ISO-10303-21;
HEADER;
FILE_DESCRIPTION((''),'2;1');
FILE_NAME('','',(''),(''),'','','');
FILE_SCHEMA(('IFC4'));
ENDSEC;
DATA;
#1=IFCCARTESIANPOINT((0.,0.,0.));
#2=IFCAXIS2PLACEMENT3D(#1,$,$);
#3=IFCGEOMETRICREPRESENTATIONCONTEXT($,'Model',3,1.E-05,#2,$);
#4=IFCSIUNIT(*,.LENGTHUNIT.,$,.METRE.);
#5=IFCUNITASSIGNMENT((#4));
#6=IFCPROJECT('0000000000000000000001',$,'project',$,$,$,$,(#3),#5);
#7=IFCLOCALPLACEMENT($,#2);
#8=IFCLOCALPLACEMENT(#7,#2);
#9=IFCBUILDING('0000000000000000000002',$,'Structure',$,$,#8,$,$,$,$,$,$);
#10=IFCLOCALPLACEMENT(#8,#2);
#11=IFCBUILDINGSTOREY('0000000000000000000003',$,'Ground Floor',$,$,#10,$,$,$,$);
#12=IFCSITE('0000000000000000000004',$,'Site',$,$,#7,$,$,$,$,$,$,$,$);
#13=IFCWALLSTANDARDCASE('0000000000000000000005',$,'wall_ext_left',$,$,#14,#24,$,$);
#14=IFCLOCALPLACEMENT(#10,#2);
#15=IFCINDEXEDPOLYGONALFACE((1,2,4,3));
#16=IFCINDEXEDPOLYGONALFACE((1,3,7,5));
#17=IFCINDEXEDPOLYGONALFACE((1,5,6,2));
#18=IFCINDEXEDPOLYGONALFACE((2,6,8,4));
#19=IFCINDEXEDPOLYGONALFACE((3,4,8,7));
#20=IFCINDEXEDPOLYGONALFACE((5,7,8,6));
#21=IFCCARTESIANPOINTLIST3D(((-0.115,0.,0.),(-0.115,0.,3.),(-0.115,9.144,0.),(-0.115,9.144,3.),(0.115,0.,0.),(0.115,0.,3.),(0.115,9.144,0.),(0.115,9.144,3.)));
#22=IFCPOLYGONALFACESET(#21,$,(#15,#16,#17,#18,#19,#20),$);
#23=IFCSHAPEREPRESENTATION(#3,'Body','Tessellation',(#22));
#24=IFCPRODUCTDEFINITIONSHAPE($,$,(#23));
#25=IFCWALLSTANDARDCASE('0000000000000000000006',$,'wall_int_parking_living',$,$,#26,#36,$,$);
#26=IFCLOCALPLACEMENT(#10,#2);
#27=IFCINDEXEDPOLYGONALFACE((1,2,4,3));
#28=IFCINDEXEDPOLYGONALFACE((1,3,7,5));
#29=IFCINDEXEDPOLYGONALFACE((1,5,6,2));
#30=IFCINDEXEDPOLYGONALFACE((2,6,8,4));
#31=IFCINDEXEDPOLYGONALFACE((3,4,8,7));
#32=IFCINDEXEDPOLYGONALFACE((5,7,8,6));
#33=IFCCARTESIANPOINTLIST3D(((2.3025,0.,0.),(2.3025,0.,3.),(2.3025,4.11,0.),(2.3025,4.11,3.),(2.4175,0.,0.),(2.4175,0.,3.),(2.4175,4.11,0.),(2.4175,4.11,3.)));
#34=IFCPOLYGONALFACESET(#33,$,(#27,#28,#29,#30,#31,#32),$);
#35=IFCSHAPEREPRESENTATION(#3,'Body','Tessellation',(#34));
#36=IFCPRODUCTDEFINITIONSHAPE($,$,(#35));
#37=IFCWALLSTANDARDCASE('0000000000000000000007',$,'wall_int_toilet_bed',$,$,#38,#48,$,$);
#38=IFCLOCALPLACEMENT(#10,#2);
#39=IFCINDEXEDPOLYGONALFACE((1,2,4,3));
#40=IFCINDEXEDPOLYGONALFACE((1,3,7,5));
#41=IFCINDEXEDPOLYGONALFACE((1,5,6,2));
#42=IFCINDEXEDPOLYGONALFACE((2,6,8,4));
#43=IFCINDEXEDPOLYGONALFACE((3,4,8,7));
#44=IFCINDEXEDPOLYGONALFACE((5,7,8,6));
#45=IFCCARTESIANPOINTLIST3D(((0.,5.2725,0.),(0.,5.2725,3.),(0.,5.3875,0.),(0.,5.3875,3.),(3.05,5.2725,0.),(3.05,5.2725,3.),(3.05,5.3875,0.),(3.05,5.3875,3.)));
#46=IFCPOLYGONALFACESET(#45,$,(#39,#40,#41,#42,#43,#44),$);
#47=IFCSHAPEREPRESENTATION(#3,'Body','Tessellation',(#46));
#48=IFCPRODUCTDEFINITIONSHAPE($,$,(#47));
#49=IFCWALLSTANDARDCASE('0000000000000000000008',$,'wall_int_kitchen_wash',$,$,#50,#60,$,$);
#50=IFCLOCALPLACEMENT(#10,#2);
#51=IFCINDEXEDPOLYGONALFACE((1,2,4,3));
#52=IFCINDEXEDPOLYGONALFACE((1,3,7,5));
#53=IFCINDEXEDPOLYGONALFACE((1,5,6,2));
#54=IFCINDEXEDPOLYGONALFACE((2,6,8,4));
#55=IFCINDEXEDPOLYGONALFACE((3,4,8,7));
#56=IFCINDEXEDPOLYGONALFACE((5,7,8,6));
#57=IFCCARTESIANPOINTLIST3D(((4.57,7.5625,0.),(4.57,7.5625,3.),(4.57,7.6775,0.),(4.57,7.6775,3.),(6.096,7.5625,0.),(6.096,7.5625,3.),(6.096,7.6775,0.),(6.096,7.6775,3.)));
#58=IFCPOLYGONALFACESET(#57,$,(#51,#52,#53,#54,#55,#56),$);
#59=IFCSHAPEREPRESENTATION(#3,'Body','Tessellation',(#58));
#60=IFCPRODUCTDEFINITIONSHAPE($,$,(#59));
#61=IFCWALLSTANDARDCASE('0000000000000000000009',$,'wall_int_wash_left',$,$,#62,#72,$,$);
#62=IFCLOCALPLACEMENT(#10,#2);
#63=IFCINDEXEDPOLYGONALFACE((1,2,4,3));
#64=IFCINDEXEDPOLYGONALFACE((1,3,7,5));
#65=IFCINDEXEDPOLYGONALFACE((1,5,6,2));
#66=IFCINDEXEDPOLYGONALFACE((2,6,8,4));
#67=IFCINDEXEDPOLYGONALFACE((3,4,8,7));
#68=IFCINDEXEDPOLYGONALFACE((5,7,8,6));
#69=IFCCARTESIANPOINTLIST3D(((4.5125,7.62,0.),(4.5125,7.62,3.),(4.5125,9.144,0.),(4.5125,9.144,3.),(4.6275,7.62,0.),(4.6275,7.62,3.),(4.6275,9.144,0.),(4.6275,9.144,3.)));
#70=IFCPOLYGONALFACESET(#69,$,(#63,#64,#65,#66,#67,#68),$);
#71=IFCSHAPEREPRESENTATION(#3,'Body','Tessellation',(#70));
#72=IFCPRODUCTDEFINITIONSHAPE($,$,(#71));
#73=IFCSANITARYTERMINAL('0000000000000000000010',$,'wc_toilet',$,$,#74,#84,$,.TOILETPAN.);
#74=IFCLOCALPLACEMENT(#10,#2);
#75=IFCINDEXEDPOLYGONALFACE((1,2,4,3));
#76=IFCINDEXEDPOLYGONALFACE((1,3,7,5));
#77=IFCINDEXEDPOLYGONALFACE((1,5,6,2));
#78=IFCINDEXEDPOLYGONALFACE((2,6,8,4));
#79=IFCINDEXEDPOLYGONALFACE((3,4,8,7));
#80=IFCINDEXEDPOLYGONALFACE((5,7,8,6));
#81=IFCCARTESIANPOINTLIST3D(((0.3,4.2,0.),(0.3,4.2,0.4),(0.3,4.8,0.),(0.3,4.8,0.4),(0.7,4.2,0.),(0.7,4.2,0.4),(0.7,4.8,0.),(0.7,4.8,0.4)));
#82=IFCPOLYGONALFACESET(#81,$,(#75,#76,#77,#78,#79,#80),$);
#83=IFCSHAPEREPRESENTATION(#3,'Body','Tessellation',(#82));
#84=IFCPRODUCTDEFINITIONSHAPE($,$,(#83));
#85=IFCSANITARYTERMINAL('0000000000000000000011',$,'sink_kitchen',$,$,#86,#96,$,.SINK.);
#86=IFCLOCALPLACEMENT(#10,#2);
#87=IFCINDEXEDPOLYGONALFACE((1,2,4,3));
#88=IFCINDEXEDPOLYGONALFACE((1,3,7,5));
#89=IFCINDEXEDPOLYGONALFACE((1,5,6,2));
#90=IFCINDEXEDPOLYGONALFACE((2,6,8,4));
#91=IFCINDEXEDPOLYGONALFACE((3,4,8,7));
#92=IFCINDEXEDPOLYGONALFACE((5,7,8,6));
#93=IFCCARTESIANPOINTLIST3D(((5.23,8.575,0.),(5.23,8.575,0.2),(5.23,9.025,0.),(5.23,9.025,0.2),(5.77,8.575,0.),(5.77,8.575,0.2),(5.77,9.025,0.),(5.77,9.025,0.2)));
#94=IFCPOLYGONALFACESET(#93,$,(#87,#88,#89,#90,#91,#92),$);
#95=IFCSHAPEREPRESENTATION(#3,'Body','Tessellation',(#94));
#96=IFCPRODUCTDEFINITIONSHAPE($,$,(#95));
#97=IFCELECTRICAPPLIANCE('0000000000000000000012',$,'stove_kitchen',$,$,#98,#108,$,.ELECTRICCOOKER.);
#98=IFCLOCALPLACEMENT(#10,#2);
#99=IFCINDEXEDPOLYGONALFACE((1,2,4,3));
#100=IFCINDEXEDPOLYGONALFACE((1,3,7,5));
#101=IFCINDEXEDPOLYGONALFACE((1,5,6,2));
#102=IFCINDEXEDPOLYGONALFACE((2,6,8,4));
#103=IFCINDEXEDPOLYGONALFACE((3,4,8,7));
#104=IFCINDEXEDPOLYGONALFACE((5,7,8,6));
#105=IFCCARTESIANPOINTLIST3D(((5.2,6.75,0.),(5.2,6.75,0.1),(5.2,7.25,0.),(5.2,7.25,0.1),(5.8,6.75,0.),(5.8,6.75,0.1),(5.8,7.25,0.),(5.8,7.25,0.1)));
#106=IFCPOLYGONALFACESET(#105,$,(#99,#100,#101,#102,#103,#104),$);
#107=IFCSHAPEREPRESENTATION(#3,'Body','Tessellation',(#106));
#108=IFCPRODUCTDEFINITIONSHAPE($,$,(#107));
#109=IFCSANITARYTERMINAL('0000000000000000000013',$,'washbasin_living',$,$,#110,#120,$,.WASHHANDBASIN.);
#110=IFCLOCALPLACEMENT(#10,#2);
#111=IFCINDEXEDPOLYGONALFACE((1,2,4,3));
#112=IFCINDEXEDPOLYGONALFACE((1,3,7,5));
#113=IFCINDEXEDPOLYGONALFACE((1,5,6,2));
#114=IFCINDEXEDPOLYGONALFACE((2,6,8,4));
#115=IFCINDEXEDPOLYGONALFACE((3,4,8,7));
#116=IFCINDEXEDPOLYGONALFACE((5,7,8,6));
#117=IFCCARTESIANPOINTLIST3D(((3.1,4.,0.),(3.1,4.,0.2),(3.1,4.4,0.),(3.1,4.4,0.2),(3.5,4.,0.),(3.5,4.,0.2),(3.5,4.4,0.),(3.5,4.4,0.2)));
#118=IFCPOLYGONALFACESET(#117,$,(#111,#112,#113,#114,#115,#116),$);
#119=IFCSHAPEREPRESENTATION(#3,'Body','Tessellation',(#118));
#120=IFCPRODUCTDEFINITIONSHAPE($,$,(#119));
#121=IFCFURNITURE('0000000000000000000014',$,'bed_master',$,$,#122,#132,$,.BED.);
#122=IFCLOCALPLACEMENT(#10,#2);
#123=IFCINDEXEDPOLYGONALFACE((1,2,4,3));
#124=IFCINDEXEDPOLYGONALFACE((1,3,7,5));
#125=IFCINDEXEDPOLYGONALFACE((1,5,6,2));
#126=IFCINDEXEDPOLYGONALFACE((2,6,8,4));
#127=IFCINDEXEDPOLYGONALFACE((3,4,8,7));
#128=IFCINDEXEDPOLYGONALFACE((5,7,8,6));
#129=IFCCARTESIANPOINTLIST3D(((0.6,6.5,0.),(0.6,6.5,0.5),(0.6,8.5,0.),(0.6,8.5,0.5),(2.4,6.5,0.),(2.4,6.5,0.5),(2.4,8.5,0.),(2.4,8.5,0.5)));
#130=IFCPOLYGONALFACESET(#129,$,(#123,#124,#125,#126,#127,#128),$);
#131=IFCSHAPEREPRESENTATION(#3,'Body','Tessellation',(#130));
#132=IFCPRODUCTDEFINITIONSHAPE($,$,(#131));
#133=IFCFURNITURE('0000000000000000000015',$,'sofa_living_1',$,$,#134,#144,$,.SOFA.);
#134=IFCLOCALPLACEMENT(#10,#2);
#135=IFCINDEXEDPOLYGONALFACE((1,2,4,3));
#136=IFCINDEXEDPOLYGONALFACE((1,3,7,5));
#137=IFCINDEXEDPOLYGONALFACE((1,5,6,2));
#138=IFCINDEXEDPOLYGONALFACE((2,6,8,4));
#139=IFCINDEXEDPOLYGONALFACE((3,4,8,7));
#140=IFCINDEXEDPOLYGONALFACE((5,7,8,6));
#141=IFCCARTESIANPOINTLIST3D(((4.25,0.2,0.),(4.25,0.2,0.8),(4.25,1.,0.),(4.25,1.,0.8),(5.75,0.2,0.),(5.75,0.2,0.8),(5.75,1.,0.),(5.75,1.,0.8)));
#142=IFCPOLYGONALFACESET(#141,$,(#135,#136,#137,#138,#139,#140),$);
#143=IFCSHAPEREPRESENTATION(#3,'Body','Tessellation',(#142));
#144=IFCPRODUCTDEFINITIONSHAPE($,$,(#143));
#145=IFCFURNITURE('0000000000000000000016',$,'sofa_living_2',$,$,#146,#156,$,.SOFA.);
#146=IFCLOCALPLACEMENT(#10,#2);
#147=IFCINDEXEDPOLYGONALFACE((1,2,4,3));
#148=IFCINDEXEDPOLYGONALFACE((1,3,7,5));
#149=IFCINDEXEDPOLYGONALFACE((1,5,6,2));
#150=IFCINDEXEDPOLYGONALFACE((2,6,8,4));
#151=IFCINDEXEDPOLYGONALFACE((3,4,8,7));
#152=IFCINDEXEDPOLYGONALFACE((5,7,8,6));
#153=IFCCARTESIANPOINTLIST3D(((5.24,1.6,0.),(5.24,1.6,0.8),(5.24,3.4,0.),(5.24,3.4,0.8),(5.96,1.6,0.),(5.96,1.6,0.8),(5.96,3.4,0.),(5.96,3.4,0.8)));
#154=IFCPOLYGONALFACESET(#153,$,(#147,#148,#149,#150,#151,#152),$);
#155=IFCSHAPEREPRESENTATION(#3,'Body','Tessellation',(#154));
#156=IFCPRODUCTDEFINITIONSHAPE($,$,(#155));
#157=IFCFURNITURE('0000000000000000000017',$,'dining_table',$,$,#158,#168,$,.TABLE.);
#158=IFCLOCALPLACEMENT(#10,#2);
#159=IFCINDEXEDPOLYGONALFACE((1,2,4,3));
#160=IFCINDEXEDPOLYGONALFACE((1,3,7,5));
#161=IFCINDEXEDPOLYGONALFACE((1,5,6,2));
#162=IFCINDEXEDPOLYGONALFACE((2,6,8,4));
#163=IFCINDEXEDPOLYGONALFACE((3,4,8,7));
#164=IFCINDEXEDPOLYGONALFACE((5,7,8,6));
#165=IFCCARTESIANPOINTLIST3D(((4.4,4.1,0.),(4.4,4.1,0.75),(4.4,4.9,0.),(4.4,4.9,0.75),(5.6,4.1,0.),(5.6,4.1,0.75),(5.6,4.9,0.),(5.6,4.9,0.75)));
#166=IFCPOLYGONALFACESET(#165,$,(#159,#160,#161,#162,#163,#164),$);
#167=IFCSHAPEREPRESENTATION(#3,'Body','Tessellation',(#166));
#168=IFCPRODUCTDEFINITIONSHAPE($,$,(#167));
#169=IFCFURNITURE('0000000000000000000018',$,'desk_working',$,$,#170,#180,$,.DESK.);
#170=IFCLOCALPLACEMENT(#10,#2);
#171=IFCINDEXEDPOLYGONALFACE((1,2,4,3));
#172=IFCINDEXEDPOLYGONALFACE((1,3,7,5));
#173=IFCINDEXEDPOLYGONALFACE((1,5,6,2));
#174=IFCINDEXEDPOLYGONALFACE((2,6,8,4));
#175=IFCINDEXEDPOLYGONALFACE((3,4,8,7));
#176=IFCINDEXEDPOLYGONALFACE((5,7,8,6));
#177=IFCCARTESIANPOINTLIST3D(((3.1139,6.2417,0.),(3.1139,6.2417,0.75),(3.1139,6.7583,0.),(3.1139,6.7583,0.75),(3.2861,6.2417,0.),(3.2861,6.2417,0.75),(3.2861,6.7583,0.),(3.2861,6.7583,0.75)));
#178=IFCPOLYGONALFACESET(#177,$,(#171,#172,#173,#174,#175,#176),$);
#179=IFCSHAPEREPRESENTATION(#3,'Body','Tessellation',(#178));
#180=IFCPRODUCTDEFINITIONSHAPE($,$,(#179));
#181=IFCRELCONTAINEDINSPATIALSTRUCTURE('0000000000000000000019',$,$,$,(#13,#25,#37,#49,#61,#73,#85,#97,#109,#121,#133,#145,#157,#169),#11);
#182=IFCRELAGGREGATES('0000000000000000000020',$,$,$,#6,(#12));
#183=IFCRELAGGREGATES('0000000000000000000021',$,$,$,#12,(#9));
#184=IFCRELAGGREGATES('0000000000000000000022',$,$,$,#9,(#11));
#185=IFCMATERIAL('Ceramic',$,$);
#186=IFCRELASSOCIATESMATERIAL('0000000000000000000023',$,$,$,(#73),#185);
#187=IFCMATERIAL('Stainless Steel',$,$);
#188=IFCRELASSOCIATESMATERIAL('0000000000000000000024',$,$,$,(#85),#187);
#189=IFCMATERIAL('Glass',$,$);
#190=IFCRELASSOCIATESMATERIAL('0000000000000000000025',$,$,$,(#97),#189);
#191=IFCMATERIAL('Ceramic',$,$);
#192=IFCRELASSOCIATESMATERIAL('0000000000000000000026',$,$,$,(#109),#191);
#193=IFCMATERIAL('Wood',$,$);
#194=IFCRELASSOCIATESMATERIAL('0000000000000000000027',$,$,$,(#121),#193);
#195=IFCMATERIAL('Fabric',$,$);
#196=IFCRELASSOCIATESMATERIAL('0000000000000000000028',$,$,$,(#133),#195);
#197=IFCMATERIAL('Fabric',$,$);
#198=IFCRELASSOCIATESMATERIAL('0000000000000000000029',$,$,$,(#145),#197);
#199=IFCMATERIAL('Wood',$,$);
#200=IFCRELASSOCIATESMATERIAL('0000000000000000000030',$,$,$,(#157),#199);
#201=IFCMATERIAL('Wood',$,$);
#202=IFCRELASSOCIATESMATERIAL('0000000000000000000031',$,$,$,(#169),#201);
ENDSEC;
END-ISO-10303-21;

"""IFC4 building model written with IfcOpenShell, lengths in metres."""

from ifc_helpers import new_model, si_unit, frame, origin, place, context, project, spatial, polyline, outline, extrude, material, element, save


model = new_model("IFC4")

# Units and contexts
model_context = context("Model", 3, precision=1e-05, world=origin())
ifc_project = project(units=[si_unit("LENGTHUNIT", "METRE")], contexts=[model_context])

# Site, building, storey
site_placement = place(None, origin())
site = spatial("IfcSite", under=ifc_project, at=site_placement, Name="Site")
building_placement = place(site_placement, origin())
building = spatial("IfcBuilding", under=site, at=building_placement, Name="Structure")
storey_placement = place(building_placement, origin())
storey = spatial("IfcBuildingStorey", under=building, at=storey_placement, Name="Ground Floor")

# Walls
wall_1_placement = place(storey_placement, frame((0.0, 0.0, 0.0), x_axis=(0.0, 1.0, 0.0)))
element("IfcWallStandardCase", 1, at=wall_1_placement, inside=storey, Name="wall_ext_left", context=model_context, shape_type="SweptSolid", body=[
    extrude(outline(polyline([(0.0, -0.115), (9.144, -0.115), (9.144, 0.115), (0.0, 0.115), (0.0, -0.115)])), origin(), (0.0, 0.0, 1.0), 3.0),
])
wall_2_placement = place(storey_placement, frame((2.36, 0.0, 0.0), x_axis=(0.0, 1.0, 0.0)))
element("IfcWallStandardCase", 2, at=wall_2_placement, inside=storey, Name="wall_int_parking_living", context=model_context, shape_type="SweptSolid", body=[
    extrude(outline(polyline([(0.0, -0.0575), (4.11, -0.0575), (4.11, 0.0575), (0.0, 0.0575), (0.0, -0.0575)])), origin(), (0.0, 0.0, 1.0), 3.0),
])
wall_3_placement = place(storey_placement, frame((0.0, 5.33, 0.0), x_axis=(1.0, 0.0, 0.0)))
element("IfcWallStandardCase", 3, at=wall_3_placement, inside=storey, Name="wall_int_toilet_bed", context=model_context, shape_type="SweptSolid", body=[
    extrude(outline(polyline([(0.0, -0.0575), (3.05, -0.0575), (3.05, 0.0575), (0.0, 0.0575), (0.0, -0.0575)])), origin(), (0.0, 0.0, 1.0), 3.0),
])
wall_4_placement = place(storey_placement, frame((4.57, 7.62, 0.0), x_axis=(1.0, 0.0, 0.0)))
element("IfcWallStandardCase", 4, at=wall_4_placement, inside=storey, Name="wall_int_kitchen_wash", context=model_context, shape_type="SweptSolid", body=[
    extrude(outline(polyline([(0.0, -0.0575), (1.526, -0.0575), (1.526, 0.0575), (0.0, 0.0575), (0.0, -0.0575)])), origin(), (0.0, 0.0, 1.0), 3.0),
])
wall_5_placement = place(storey_placement, frame((4.57, 7.62, 0.0), x_axis=(0.0, 1.0, 0.0)))
element("IfcWallStandardCase", 5, at=wall_5_placement, inside=storey, Name="wall_int_wash_left", context=model_context, shape_type="SweptSolid", body=[
    extrude(outline(polyline([(0.0, -0.0575), (1.524, -0.0575), (1.524, 0.0575), (0.0, 0.0575), (0.0, -0.0575)])), origin(), (0.0, 0.0, 1.0), 3.0),
])

# Sanitary terminals
ifc_material_1 = material(Name="Ceramic")
sanitary_terminal_1_placement = place(storey_placement, frame((0.5, 4.5, 0.0)))
element("IfcSanitaryTerminal", 6, at=sanitary_terminal_1_placement, inside=storey, material=ifc_material_1, Name="wc_toilet", PredefinedType="TOILETPAN", context=model_context, shape_type="SweptSolid", body=[
    extrude(outline(polyline([(-0.2, -0.3), (0.2, -0.3), (0.2, 0.3), (-0.2, 0.3), (-0.2, -0.3)])), origin(), (0.0, 0.0, 1.0), 0.4),
])
ifc_material_2 = material(Name="Stainless Steel")
sanitary_terminal_2_placement = place(storey_placement, frame((5.5, 8.8, 0.0)))
element("IfcSanitaryTerminal", 7, at=sanitary_terminal_2_placement, inside=storey, material=ifc_material_2, Name="sink_kitchen", PredefinedType="SINK", context=model_context, shape_type="SweptSolid", body=[
    extrude(outline(polyline([(-0.27, -0.225), (0.27, -0.225), (0.27, 0.225), (-0.27, 0.225), (-0.27, -0.225)])), origin(), (0.0, 0.0, 1.0), 0.2),
])

# Electric appliance
ifc_material_3 = material(Name="Glass")
electric_appliance_placement = place(storey_placement, frame((5.5, 7.0, 0.0)))
element("IfcElectricAppliance", 8, at=electric_appliance_placement, inside=storey, material=ifc_material_3, Name="stove_kitchen", PredefinedType="ELECTRICCOOKER", context=model_context, shape_type="SweptSolid", body=[
    extrude(outline(polyline([(-0.3, -0.25), (0.3, -0.25), (0.3, 0.25), (-0.3, 0.25), (-0.3, -0.25)])), origin(), (0.0, 0.0, 1.0), 0.1),
])

# Sanitary terminal
ifc_material_4 = material(Name="Ceramic")
sanitary_terminal_3_placement = place(storey_placement, frame((3.3, 4.2, 0.0)))
element("IfcSanitaryTerminal", 9, at=sanitary_terminal_3_placement, inside=storey, material=ifc_material_4, Name="washbasin_living", PredefinedType="WASHHANDBASIN", context=model_context, shape_type="SweptSolid", body=[
    extrude(outline(polyline([(-0.2, -0.2), (0.2, -0.2), (0.2, 0.2), (-0.2, 0.2), (-0.2, -0.2)])), origin(), (0.0, 0.0, 1.0), 0.2),
])

# Furniture
ifc_material_5 = material(Name="Wood")
furniture_1_placement = place(storey_placement, frame((1.5, 7.5, 0.0)))
element("IfcFurniture", 10, at=furniture_1_placement, inside=storey, material=ifc_material_5, Name="bed_master", PredefinedType="BED", context=model_context, shape_type="SweptSolid", body=[
    extrude(outline(polyline([(-0.9, -1.0), (0.9, -1.0), (0.9, 1.0), (-0.9, 1.0), (-0.9, -1.0)])), origin(), (0.0, 0.0, 1.0), 0.5),
])
ifc_material_6 = material(Name="Fabric")
furniture_2_placement = place(storey_placement, frame((5.0, 0.6, 0.0)))
element("IfcFurniture", 11, at=furniture_2_placement, inside=storey, material=ifc_material_6, Name="sofa_living_1", PredefinedType="SOFA", context=model_context, shape_type="SweptSolid", body=[
    extrude(outline(polyline([(-0.75, -0.4), (0.75, -0.4), (0.75, 0.4), (-0.75, 0.4), (-0.75, -0.4)])), origin(), (0.0, 0.0, 1.0), 0.8),
])
ifc_material_7 = material(Name="Fabric")
furniture_3_placement = place(storey_placement, frame((5.6, 2.5, 0.0)))
element("IfcFurniture", 12, at=furniture_3_placement, inside=storey, material=ifc_material_7, Name="sofa_living_2", PredefinedType="SOFA", context=model_context, shape_type="SweptSolid", body=[
    extrude(outline(polyline([(-0.36, -0.9), (0.36, -0.9), (0.36, 0.9), (-0.36, 0.9), (-0.36, -0.9)])), origin(), (0.0, 0.0, 1.0), 0.8),
])
ifc_material_8 = material(Name="Wood")
furniture_4_placement = place(storey_placement, frame((5.0, 4.5, 0.0)))
element("IfcFurniture", 13, at=furniture_4_placement, inside=storey, material=ifc_material_8, Name="dining_table", PredefinedType="TABLE", context=model_context, shape_type="SweptSolid", body=[
    extrude(outline(polyline([(-0.6, -0.4), (0.6, -0.4), (0.6, 0.4), (-0.6, 0.4), (-0.6, -0.4)])), origin(), (0.0, 0.0, 1.0), 0.75),
])
ifc_material_9 = material(Name="Wood")
furniture_5_placement = place(storey_placement, frame((3.2, 6.5, 0.0)))
element("IfcFurniture", 14, at=furniture_5_placement, inside=storey, material=ifc_material_9, Name="desk_working", PredefinedType="DESK", context=model_context, shape_type="SweptSolid", body=[
    extrude(outline(polyline([(-0.0861, -0.2583), (0.0861, -0.2583), (0.0861, 0.2583), (-0.0861, 0.2583), (-0.0861, -0.2583)])), origin(), (0.0, 0.0, 1.0), 0.75),
])

save(model, "model.ifc")
